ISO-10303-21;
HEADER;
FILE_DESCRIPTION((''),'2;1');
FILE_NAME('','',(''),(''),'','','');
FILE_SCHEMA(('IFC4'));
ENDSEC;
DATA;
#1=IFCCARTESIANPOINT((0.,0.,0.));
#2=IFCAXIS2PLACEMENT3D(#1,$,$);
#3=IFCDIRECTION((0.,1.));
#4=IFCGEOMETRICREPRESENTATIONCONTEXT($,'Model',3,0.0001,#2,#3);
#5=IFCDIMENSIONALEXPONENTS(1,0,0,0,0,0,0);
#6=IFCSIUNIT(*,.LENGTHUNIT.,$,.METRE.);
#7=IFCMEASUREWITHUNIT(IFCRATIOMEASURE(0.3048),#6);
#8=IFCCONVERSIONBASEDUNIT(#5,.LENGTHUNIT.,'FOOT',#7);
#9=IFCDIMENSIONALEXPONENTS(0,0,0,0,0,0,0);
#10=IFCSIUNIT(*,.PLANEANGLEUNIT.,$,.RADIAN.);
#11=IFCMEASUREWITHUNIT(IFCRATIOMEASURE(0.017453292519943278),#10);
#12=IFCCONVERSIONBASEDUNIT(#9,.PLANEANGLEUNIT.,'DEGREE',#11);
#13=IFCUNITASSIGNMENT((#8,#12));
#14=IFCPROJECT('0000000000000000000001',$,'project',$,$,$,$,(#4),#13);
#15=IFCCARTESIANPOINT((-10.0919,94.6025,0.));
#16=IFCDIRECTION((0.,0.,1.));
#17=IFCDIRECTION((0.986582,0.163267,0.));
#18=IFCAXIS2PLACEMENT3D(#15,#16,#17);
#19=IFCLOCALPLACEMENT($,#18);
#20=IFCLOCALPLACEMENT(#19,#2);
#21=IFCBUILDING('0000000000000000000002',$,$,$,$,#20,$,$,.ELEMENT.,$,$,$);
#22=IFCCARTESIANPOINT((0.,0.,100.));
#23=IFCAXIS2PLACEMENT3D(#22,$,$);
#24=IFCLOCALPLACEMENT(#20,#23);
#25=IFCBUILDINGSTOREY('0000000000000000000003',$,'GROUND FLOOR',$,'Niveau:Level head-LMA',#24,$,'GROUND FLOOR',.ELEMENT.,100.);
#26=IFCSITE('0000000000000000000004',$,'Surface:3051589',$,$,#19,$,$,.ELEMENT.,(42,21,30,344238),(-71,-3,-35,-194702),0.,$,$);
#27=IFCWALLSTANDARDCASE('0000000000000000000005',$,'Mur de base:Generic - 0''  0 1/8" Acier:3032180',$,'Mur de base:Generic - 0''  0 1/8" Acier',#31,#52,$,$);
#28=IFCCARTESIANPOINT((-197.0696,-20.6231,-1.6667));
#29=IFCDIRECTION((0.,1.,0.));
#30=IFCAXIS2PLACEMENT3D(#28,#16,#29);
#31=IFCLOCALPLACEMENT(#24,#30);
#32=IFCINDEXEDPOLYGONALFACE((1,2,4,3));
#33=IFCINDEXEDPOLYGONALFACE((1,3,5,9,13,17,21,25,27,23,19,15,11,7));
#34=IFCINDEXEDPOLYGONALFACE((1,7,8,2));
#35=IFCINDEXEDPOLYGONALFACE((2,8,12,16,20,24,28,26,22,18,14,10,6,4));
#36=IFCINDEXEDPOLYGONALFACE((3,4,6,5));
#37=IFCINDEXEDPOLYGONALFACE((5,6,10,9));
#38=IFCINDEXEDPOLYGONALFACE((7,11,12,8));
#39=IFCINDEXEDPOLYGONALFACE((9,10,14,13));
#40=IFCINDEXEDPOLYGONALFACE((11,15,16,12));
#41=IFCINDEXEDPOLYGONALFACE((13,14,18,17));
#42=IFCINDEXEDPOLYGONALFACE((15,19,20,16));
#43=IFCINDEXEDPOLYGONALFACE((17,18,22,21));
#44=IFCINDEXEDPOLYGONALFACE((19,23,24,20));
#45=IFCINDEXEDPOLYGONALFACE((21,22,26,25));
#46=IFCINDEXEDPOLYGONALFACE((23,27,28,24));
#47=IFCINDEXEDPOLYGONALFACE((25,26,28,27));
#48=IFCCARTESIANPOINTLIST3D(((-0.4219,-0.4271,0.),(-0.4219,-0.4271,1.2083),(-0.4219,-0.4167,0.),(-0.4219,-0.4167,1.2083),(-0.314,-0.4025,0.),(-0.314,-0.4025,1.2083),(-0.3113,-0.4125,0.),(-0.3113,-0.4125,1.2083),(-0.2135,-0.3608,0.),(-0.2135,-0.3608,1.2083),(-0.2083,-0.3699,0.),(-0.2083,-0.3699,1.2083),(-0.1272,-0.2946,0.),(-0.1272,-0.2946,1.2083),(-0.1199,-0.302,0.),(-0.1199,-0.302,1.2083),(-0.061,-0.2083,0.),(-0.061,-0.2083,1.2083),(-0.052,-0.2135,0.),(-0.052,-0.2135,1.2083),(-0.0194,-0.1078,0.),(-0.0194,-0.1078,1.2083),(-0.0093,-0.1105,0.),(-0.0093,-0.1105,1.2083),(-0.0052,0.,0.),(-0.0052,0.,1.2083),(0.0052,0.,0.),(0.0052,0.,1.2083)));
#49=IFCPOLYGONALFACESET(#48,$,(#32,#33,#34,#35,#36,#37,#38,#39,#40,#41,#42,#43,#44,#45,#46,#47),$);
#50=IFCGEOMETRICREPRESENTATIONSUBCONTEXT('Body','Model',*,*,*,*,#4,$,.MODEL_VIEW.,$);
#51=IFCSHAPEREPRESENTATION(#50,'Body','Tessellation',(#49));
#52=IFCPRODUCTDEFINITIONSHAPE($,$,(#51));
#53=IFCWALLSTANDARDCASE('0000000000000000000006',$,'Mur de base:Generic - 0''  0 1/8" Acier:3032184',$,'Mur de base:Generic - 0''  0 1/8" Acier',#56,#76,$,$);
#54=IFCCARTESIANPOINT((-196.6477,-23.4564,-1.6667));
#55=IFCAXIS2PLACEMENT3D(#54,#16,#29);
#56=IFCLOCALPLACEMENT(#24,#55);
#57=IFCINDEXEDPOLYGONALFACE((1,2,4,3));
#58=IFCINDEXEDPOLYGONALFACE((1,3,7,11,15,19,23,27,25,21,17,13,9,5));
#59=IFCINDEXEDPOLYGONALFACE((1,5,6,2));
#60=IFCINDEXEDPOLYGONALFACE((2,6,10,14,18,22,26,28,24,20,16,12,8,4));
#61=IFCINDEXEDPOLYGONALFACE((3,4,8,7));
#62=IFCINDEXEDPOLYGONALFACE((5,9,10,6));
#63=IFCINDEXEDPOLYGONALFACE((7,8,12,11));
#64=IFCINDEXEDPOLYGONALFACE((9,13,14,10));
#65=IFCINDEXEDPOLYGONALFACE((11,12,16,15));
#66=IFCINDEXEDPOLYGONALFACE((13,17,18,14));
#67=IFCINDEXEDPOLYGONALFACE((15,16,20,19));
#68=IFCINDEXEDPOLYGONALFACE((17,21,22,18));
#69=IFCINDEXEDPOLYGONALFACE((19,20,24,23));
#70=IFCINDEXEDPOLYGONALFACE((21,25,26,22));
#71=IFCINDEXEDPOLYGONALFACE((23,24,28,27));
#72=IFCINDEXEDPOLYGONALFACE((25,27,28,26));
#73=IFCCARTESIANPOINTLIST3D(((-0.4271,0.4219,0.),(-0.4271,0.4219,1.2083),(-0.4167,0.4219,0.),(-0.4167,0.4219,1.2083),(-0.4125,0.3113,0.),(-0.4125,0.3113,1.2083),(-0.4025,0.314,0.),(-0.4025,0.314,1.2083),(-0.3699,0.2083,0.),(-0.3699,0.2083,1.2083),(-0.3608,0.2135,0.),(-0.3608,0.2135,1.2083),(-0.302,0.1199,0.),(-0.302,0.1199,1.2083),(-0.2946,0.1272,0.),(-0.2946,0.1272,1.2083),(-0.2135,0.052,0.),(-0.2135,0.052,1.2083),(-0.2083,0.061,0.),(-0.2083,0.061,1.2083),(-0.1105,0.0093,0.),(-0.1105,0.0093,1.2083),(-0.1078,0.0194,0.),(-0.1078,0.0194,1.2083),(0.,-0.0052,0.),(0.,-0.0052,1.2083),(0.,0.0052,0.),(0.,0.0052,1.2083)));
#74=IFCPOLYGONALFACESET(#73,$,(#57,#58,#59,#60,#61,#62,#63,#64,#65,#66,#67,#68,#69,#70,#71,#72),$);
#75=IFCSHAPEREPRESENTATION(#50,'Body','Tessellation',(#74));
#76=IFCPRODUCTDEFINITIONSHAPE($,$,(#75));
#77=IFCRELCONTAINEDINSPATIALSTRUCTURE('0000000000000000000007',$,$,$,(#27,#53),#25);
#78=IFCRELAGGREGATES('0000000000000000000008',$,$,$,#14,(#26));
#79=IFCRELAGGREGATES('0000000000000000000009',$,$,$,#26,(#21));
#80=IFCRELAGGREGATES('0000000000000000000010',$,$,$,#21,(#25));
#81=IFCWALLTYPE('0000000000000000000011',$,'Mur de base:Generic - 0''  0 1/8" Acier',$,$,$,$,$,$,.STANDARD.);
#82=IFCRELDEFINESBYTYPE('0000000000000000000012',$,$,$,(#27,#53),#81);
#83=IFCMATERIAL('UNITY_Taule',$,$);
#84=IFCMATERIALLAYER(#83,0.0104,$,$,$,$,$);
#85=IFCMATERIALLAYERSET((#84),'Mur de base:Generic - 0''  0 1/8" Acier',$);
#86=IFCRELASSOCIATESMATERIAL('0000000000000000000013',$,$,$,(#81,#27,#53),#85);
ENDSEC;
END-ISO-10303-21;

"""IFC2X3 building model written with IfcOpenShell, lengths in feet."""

from ifc_helpers import new_model, entity, si_unit, converted_unit, direction, frame, frame_2d, origin, place, context, subcontext, project, spatial, polyline, circle_curve, parameter, trimmed, segment, composite_curve, outline, extrude, material, layer, layer_set, layer_usage, type_object, element, save


model = new_model("IFC2X3")

# Units and contexts
model_context = context("Model", 3, precision=0.0001, world=origin(), true_north=direction((0.0, 1.0)))
body_context = subcontext(model_context, "Body", "Model", "MODEL_VIEW")
ifc_project = project(units=[converted_unit("LENGTHUNIT", "FOOT", entity("IfcRatioMeasure", 0.3048), si_unit("LENGTHUNIT", "METRE"), dimensions=[1, 0, 0, 0, 0, 0, 0]), converted_unit("PLANEANGLEUNIT", "DEGREE", entity("IfcRatioMeasure", 0.017453292519943278), si_unit("PLANEANGLEUNIT", "RADIAN"), dimensions=[0, 0, 0, 0, 0, 0, 0])], contexts=[model_context])

# Site, building, storey
site_placement = place(None, frame((-10.0919, 94.6025, 0.0), z_axis=(0.0, 0.0, 1.0), x_axis=(0.986582, 0.163267, 0.0)))
site = spatial("IfcSite", under=ifc_project, at=site_placement, Name="Surface:3051589", CompositionType="ELEMENT", RefLatitude=(42, 21, 30, 344238), RefLongitude=(-71, -3, -35, -194702), RefElevation=0.0)
building_placement = place(site_placement, origin())
building = spatial("IfcBuilding", under=site, at=building_placement, CompositionType="ELEMENT")
storey_placement = place(building_placement, frame((0.0, 0.0, 100.0)))
storey = spatial("IfcBuildingStorey", under=building, at=storey_placement, Name="GROUND FLOOR", ObjectType="Niveau:Level head-LMA", LongName="GROUND FLOOR", CompositionType="ELEMENT", Elevation=100.0)

# Walls
ifc_material_1 = material(Name="UNITY_Taule")
ifc_layer_1 = layer(ifc_material_1, 0.0104)
ifc_layer_set_1 = layer_set([ifc_layer_1], Name="Mur de base:Generic - 0'  0 1/8\" Acier")
ifc_layer_usage_1 = layer_usage(ifc_layer_set_1, "AXIS2", "NEGATIVE", 0.0052)
wall_type_1 = type_object("IfcWallType", Name="Mur de base:Generic - 0'  0 1/8\" Acier", PredefinedType="STANDARD", material=ifc_layer_set_1)
wall_1_placement = place(storey_placement, frame((-197.0696, -20.6231, -1.6667), z_axis=(0.0, 0.0, 1.0), x_axis=(0.0, 1.0, 0.0)))
element("IfcWallStandardCase", 1, at=wall_1_placement, inside=storey, type_object=wall_type_1, material=ifc_layer_usage_1, Name="Mur de base:Generic - 0'  0 1/8\" Acier:3032180", ObjectType="Mur de base:Generic - 0'  0 1/8\" Acier", context=body_context, shape_type="SweptSolid", body=[
    extrude(outline(composite_curve([segment(trimmed(circle_curve(frame_2d((-0.4219, 0.0), x_axis=(1.0, 0.0)), 0.4271), [parameter(270.0)], [parameter(360.0)], True, "PARAMETER"), True, "CONTINUOUS"), segment(polyline([(0.0052, 0.0), (-0.0052, 0.0)]), True, "CONTINUOUS"), segment(trimmed(circle_curve(frame_2d((-0.4219, 0.0), x_axis=(1.0, 0.0)), 0.4167), [parameter(270.0)], [parameter(360.0)], True, "PARAMETER"), False, "CONTINUOUS"), segment(polyline([(-0.4219, -0.4167), (-0.4219, -0.4271)]), True, "CONTINUOUS")], self_intersect=False)), origin(), (0.0, 0.0, 1.0), 1.2083),
])
ifc_layer_usage_2 = layer_usage(ifc_layer_set_1, "AXIS2", "NEGATIVE", 0.0052)
wall_2_placement = place(storey_placement, frame((-196.6477, -23.4564, -1.6667), z_axis=(0.0, 0.0, 1.0), x_axis=(0.0, 1.0, 0.0)))
element("IfcWallStandardCase", 2, at=wall_2_placement, inside=storey, type_object=wall_type_1, material=ifc_layer_usage_2, Name="Mur de base:Generic - 0'  0 1/8\" Acier:3032184", ObjectType="Mur de base:Generic - 0'  0 1/8\" Acier", context=body_context, shape_type="SweptSolid", body=[
    extrude(outline(composite_curve([segment(trimmed(circle_curve(frame_2d((0.0, 0.4219), x_axis=(1.0, 0.0)), 0.4271), [parameter(180.0)], [parameter(270.0)], True, "PARAMETER"), True, "CONTINUOUS"), segment(polyline([(0.0, -0.0052), (0.0, 0.0052)]), True, "CONTINUOUS"), segment(trimmed(circle_curve(frame_2d((0.0, 0.4219), x_axis=(1.0, 0.0)), 0.4167), [parameter(180.0)], [parameter(270.0)], True, "PARAMETER"), False, "CONTINUOUS"), segment(polyline([(-0.4167, 0.4219), (-0.4271, 0.4219)]), True, "CONTINUOUS")], self_intersect=False)), origin(), (0.0, 0.0, 1.0), 1.2083),
])

save(model, "model.ifc")
